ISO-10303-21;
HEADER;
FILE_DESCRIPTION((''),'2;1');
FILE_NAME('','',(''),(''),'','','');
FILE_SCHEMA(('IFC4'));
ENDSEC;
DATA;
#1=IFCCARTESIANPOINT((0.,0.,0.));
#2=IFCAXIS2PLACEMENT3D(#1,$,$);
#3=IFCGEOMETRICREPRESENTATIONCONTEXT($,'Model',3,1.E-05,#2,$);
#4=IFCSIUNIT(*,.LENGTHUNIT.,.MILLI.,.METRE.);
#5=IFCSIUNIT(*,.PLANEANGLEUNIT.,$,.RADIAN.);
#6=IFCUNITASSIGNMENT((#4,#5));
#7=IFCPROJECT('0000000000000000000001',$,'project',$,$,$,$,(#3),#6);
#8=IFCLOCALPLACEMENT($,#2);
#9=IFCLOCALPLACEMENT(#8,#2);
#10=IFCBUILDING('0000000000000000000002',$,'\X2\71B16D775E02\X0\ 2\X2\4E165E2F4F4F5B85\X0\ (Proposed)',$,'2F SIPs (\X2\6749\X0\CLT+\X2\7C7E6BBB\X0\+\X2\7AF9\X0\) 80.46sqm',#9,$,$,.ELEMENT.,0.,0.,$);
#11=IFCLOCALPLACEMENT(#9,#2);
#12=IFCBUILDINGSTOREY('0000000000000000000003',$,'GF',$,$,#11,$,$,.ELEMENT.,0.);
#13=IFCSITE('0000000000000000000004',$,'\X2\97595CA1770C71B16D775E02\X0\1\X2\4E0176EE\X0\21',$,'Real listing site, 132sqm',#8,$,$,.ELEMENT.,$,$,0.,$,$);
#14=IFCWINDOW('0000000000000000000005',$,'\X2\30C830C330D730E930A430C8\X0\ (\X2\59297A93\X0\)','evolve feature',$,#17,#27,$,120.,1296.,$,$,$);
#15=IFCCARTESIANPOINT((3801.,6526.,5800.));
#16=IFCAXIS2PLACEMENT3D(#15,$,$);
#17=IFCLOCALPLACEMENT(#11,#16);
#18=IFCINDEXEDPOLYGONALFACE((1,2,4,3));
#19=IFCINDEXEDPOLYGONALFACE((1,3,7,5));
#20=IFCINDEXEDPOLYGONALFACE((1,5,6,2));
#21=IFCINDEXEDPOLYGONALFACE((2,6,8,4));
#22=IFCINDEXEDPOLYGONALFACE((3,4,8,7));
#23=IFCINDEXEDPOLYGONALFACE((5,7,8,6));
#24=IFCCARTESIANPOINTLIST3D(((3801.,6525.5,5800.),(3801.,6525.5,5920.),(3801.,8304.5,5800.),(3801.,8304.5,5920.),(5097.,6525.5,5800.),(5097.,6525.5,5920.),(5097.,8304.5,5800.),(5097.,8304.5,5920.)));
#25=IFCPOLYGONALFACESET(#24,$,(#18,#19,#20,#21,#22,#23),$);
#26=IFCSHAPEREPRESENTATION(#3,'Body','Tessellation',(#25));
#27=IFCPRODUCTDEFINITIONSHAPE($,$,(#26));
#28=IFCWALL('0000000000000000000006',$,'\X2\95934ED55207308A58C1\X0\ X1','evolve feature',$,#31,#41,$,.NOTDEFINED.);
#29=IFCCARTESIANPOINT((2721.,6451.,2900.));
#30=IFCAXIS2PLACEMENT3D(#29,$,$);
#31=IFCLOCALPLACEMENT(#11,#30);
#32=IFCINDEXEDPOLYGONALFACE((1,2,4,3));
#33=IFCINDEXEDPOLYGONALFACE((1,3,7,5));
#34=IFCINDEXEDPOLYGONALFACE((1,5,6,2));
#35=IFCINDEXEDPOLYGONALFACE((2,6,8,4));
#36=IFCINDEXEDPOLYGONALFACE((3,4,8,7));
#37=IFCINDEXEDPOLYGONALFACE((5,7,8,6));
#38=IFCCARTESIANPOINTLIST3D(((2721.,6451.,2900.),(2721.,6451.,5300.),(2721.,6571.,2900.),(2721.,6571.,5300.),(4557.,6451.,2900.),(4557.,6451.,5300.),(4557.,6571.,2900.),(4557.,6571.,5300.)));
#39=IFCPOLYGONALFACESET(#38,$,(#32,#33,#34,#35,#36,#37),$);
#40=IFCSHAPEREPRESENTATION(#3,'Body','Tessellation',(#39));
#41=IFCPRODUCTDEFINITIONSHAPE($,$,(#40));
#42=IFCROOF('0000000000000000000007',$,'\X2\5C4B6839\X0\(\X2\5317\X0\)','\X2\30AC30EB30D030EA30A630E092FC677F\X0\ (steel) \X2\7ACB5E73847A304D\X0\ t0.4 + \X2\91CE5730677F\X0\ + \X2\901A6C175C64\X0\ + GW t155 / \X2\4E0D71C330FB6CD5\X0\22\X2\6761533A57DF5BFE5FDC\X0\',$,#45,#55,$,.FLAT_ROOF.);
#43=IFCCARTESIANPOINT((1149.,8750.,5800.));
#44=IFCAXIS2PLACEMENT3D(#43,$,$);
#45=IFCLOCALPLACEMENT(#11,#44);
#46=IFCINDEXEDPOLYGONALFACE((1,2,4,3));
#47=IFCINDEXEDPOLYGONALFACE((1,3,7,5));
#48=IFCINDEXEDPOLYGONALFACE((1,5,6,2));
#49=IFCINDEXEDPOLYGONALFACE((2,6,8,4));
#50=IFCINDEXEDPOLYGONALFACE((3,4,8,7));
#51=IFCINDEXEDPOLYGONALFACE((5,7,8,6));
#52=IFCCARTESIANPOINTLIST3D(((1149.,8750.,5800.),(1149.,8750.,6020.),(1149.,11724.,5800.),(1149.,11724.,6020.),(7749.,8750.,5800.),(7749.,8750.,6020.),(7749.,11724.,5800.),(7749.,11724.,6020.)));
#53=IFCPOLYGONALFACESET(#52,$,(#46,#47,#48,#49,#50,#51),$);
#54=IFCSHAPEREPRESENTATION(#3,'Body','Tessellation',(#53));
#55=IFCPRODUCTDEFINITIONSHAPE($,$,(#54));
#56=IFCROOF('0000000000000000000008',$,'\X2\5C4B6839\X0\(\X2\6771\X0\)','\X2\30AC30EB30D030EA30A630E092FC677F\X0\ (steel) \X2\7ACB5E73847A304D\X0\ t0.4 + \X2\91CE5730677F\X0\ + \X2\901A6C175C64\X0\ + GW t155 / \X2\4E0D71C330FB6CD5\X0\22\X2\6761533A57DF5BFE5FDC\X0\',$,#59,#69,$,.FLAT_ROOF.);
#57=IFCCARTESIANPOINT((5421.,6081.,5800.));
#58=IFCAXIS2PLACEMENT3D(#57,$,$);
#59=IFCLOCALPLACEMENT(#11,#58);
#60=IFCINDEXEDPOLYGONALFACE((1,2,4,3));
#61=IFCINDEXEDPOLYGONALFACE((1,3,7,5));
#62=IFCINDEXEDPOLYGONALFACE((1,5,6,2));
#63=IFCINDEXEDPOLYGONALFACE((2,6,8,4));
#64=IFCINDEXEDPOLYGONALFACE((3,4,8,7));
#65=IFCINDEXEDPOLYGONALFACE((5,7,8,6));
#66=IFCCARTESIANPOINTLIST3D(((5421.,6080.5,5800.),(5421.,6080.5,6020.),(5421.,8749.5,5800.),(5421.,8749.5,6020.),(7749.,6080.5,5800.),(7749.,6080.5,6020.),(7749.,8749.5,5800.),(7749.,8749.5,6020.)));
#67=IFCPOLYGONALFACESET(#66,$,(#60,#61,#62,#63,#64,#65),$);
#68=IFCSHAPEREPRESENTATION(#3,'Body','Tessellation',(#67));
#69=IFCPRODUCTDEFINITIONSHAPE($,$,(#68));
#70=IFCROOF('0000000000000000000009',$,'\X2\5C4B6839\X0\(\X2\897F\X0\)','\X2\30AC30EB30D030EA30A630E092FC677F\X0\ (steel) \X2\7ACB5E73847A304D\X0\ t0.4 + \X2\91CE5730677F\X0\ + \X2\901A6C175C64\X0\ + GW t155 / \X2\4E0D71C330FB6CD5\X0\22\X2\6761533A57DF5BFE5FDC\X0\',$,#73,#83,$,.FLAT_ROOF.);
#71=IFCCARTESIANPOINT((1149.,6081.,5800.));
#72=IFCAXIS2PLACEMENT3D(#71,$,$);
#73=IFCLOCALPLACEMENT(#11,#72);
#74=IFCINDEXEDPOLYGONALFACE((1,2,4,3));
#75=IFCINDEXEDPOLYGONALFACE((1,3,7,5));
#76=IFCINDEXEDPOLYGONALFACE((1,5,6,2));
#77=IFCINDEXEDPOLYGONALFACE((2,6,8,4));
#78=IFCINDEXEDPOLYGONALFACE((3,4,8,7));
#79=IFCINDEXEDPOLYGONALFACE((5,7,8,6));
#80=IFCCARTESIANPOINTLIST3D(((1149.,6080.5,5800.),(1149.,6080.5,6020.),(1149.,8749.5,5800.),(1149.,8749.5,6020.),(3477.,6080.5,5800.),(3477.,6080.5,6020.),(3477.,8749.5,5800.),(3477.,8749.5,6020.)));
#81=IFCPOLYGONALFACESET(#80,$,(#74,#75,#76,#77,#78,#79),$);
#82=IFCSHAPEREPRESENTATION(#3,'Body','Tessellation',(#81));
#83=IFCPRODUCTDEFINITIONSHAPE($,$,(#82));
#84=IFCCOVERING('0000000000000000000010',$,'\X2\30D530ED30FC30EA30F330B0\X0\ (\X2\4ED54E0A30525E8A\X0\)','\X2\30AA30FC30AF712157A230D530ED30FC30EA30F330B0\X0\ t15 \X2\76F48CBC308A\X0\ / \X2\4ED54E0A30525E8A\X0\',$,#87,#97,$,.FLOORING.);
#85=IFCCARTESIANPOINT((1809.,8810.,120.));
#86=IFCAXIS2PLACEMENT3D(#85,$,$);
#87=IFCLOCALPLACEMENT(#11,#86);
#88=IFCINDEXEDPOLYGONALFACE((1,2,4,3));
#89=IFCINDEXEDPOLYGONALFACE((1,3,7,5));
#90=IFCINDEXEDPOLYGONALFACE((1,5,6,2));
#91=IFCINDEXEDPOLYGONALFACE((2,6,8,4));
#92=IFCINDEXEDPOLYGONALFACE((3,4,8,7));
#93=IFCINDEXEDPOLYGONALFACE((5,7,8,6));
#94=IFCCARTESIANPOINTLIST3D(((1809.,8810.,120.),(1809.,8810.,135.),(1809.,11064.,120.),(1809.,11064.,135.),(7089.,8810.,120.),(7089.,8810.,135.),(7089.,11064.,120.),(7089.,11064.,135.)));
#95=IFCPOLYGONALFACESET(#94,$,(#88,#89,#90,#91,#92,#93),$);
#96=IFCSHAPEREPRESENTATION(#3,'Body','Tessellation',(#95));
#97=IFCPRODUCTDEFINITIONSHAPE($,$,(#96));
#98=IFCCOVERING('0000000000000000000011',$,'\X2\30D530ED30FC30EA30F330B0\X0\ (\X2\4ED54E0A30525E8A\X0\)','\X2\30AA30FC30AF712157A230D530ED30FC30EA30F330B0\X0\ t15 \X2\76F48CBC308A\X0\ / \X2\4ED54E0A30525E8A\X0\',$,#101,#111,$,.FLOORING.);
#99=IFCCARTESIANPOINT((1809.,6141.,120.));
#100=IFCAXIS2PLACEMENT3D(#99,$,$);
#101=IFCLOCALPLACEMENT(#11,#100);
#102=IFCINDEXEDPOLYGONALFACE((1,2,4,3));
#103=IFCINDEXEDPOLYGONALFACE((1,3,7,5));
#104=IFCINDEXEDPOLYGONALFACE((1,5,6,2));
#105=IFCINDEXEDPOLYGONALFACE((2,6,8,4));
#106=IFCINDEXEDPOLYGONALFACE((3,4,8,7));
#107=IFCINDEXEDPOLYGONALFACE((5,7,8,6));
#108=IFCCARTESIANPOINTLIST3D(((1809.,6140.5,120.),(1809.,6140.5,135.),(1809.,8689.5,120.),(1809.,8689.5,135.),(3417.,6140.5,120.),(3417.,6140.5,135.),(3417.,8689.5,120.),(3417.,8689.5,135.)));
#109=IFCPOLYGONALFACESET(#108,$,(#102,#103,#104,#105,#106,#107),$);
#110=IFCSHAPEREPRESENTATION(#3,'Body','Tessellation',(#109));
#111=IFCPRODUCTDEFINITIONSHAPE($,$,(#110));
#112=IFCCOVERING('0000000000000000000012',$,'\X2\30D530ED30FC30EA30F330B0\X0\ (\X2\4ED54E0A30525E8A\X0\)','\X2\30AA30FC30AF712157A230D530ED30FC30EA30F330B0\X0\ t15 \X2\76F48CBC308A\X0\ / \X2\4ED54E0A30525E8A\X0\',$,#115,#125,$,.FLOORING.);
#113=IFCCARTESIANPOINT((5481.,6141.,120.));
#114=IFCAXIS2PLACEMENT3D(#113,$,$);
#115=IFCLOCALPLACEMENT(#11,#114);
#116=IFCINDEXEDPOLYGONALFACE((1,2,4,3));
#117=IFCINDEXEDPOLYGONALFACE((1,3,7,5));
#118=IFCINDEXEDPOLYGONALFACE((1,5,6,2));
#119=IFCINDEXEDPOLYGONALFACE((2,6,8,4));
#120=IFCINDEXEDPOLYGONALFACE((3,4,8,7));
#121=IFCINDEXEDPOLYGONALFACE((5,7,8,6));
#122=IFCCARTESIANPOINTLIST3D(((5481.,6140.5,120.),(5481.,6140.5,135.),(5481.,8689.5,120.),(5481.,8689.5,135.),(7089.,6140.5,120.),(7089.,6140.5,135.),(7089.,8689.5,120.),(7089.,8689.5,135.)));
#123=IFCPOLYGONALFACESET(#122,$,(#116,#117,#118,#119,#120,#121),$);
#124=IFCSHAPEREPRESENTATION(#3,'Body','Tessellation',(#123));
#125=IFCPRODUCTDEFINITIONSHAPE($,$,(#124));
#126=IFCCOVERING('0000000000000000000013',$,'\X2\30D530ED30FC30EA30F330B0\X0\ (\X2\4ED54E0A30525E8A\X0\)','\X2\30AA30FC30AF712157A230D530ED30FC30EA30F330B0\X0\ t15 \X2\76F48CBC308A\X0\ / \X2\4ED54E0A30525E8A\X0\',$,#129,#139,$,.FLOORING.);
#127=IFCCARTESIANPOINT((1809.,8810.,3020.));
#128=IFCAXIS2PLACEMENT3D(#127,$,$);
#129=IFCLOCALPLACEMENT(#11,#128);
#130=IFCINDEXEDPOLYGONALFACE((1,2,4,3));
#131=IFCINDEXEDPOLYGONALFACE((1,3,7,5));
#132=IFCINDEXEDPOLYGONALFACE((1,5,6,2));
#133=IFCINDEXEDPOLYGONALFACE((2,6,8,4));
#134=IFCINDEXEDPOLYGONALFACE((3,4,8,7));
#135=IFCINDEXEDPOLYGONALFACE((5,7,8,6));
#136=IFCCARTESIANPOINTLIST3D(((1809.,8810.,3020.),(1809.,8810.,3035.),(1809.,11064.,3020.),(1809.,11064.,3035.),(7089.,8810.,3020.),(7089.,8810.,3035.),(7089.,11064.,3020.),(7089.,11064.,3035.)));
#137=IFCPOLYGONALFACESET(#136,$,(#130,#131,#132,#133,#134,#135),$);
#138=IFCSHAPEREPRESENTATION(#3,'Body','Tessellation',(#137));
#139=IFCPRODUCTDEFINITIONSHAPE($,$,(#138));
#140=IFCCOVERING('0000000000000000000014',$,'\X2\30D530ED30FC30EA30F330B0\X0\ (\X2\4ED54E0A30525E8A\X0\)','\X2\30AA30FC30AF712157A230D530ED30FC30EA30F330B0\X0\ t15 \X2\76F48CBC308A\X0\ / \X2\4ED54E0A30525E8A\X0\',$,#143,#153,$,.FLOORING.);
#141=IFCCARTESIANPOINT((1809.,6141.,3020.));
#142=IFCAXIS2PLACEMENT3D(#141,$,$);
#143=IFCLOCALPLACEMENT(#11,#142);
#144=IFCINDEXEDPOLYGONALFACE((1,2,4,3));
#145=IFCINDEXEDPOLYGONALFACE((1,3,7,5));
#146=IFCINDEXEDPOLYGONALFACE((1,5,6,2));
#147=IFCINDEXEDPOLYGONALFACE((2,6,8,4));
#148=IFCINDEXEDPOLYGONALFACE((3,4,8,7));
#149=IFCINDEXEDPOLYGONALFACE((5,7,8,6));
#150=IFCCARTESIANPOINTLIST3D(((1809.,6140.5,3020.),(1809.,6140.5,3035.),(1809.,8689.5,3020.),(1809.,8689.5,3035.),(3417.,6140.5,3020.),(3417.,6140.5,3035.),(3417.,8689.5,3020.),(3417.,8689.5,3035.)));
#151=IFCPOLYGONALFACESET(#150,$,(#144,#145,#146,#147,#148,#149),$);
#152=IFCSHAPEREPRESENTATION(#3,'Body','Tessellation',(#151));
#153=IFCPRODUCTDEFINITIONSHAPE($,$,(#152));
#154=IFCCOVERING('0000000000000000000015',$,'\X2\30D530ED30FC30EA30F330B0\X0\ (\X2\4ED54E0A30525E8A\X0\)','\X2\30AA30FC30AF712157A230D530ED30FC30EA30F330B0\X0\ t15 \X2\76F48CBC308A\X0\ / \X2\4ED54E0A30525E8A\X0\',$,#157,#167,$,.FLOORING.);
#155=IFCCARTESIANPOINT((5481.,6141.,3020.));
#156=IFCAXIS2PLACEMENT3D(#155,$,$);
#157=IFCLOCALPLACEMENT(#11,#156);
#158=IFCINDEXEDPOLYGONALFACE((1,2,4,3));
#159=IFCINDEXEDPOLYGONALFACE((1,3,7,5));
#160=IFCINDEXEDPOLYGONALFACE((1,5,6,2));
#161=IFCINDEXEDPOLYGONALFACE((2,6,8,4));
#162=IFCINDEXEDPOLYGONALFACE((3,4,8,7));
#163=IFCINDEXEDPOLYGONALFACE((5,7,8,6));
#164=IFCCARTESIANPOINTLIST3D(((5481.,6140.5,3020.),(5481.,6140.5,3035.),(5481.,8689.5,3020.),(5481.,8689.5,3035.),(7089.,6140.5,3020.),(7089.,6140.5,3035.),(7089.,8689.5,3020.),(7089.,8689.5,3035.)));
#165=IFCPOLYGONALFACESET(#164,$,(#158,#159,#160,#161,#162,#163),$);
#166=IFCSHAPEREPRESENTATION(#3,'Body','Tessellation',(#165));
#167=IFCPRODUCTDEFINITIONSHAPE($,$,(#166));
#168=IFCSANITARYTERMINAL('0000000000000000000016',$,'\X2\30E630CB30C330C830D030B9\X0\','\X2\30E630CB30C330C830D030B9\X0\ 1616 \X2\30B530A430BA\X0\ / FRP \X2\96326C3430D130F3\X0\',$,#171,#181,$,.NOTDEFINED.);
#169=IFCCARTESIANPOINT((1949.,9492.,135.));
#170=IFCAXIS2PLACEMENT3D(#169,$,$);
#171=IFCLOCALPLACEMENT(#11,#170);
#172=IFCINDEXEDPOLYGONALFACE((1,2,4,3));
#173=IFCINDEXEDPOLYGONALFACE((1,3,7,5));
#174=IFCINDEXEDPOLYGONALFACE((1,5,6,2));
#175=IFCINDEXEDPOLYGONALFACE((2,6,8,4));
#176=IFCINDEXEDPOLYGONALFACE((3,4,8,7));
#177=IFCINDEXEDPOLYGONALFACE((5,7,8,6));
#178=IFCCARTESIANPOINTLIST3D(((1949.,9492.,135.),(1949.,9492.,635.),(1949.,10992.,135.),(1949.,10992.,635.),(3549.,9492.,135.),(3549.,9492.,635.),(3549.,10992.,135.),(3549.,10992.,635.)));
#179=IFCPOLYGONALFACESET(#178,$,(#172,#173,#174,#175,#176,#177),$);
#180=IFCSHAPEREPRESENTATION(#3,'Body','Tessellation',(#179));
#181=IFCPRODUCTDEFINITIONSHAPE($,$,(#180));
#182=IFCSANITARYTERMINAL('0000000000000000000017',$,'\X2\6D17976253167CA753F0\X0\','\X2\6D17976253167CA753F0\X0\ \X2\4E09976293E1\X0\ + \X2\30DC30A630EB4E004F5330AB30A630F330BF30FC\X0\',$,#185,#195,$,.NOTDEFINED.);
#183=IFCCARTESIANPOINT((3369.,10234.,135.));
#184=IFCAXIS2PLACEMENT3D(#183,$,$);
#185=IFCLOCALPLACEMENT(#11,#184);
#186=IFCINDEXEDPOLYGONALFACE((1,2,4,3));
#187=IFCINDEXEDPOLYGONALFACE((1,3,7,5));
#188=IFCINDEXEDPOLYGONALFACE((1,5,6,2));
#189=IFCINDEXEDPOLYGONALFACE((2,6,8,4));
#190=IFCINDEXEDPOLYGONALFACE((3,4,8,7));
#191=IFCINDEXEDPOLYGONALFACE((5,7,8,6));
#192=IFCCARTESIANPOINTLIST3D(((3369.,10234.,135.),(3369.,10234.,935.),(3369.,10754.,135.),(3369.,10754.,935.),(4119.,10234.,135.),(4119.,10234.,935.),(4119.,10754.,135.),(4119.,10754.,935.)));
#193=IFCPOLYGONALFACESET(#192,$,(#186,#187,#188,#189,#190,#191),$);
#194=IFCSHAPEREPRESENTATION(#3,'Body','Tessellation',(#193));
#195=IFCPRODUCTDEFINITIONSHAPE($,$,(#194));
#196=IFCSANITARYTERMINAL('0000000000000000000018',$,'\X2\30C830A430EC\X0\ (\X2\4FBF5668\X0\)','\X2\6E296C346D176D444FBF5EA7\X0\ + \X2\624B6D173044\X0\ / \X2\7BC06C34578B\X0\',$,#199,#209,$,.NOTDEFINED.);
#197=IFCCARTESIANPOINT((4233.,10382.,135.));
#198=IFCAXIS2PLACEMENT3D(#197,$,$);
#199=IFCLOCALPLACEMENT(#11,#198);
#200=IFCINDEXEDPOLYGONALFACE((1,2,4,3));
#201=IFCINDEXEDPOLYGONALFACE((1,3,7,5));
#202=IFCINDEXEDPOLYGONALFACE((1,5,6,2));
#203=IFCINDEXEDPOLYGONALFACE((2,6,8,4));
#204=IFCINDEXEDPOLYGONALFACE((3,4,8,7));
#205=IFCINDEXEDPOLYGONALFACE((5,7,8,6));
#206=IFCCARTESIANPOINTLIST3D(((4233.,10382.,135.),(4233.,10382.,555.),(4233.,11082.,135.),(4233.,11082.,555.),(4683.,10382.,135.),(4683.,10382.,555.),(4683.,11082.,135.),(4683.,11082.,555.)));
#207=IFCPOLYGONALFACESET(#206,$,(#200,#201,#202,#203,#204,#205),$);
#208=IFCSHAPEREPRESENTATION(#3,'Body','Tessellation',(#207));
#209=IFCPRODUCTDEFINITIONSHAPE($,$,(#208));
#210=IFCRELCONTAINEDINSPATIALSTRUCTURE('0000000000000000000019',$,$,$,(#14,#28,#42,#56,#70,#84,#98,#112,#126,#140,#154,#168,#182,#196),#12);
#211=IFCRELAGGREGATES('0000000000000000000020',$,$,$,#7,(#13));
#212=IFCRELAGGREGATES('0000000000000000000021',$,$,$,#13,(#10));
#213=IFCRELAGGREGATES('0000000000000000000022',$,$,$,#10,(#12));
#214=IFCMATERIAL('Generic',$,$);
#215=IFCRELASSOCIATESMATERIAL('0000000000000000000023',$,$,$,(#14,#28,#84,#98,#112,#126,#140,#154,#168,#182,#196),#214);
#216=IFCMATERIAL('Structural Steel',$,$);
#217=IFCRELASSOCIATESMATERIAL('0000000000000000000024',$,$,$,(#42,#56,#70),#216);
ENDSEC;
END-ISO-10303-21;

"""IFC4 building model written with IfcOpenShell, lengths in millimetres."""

from ifc_helpers import new_model, si_unit, frame, frame_2d, origin, place, context, project, spatial, rectangle, extrude, material, element, save


model = new_model("IFC4")

# Units and contexts
model_context = context("Model", 3, precision=1e-05, world=origin())
ifc_project = project(units=[si_unit("LENGTHUNIT", "METRE", prefix="MILLI"), si_unit("PLANEANGLEUNIT", "RADIAN")], contexts=[model_context])

# Site, building, storey
site_placement = place(None, origin())
site = spatial("IfcSite", under=ifc_project, at=site_placement, Name="静岡県熱海市1丁目21", ObjectType="Real listing site, 132sqm", CompositionType="ELEMENT", RefElevation=0.0)
building_placement = place(site_placement, origin())
building = spatial("IfcBuilding", under=site, at=building_placement, Name="熱海市 2世帯住宅 (Proposed)", ObjectType="2F SIPs (杉CLT+籾殻+竹) 80.46sqm", CompositionType="ELEMENT", ElevationOfRefHeight=0.0, ElevationOfTerrain=0.0)
storey_placement = place(building_placement, origin())
storey = spatial("IfcBuildingStorey", under=building, at=storey_placement, Name="GF", CompositionType="ELEMENT", Elevation=0.0)

# Window
ifc_material_1 = material(Name="Generic")
window_1_placement = place(storey_placement, frame((3801.0, 6526.0, 5800.0)))
element("IfcWindow", 1, at=window_1_placement, inside=storey, material=ifc_material_1, Name="トップライト (天窓)", Description="evolve feature", OverallHeight=120.0, OverallWidth=1296.0, context=model_context, shape_type="SweptSolid", body=[
    extrude(rectangle(XDim=1296.0, YDim=1779.0, at=frame_2d((648.0, 889.0))), frame((3801.0, 6526.0, 5800.0)), (0.0, 0.0, 1.0), 120.0),
])

# Wall
wall_1_placement = place(storey_placement, frame((2721.0, 6451.0, 2900.0)))
element("IfcWall", 2, at=wall_1_placement, inside=storey, material=ifc_material_1, Name="間仕切り壁 X1", Description="evolve feature", PredefinedType="NOTDEFINED", context=model_context, shape_type="SweptSolid", body=[
    extrude(rectangle(XDim=1836.0, YDim=120.0, at=frame_2d((918.0, 60.0))), frame((2721.0, 6451.0, 2900.0)), (0.0, 0.0, 1.0), 2400.0),
])

# Roofs
ifc_material_2 = material(Name="Structural Steel")
roof_1_placement = place(storey_placement, frame((1149.0, 8750.0, 5800.0)))
element("IfcRoof", 3, at=roof_1_placement, inside=storey, material=ifc_material_2, Name="屋根(北)", Description="ガルバリウム鋼板 (steel) 立平葺き t0.4 + 野地板 + 通気層 + GW t155 / 不燃・法22条区域対応", PredefinedType="FLAT_ROOF", context=model_context, shape_type="SweptSolid", body=[
    extrude(rectangle(XDim=6600.0, YDim=2974.0, at=frame_2d((3300.0, 1487.0))), frame((1149.0, 8750.0, 5800.0)), (0.0, 0.0, 1.0), 220.0),
])
roof_2_placement = place(storey_placement, frame((5421.0, 6081.0, 5800.0)))
element("IfcRoof", 4, at=roof_2_placement, inside=storey, material=ifc_material_2, Name="屋根(東)", Description="ガルバリウム鋼板 (steel) 立平葺き t0.4 + 野地板 + 通気層 + GW t155 / 不燃・法22条区域対応", PredefinedType="FLAT_ROOF", context=model_context, shape_type="SweptSolid", body=[
    extrude(rectangle(XDim=2328.0, YDim=2669.0, at=frame_2d((1164.0, 1334.0))), frame((5421.0, 6081.0, 5800.0)), (0.0, 0.0, 1.0), 220.0),
])
roof_3_placement = place(storey_placement, frame((1149.0, 6081.0, 5800.0)))
element("IfcRoof", 5, at=roof_3_placement, inside=storey, material=ifc_material_2, Name="屋根(西)", Description="ガルバリウム鋼板 (steel) 立平葺き t0.4 + 野地板 + 通気層 + GW t155 / 不燃・法22条区域対応", PredefinedType="FLAT_ROOF", context=model_context, shape_type="SweptSolid", body=[
    extrude(rectangle(XDim=2328.0, YDim=2669.0, at=frame_2d((1164.0, 1334.0))), frame((1149.0, 6081.0, 5800.0)), (0.0, 0.0, 1.0), 220.0),
])

# Coverings
covering_1_placement = place(storey_placement, frame((1809.0, 8810.0, 120.0)))
element("IfcCovering", 6, at=covering_1_placement, inside=storey, material=ifc_material_1, Name="フローリング (仕上げ床)", Description="オーク無垢フローリング t15 直貼り / 仕上げ床", PredefinedType="FLOORING", context=model_context, shape_type="SweptSolid", body=[
    extrude(rectangle(XDim=5280.0, YDim=2254.0, at=frame_2d((2640.0, 1127.0))), frame((1809.0, 8810.0, 120.0)), (0.0, 0.0, 1.0), 15.0),
])
covering_2_placement = place(storey_placement, frame((1809.0, 6141.0, 120.0)))
element("IfcCovering", 7, at=covering_2_placement, inside=storey, material=ifc_material_1, Name="フローリング (仕上げ床)", Description="オーク無垢フローリング t15 直貼り / 仕上げ床", PredefinedType="FLOORING", context=model_context, shape_type="SweptSolid", body=[
    extrude(rectangle(XDim=1608.0, YDim=2549.0, at=frame_2d((804.0, 1274.0))), frame((1809.0, 6141.0, 120.0)), (0.0, 0.0, 1.0), 15.0),
])
covering_3_placement = place(storey_placement, frame((5481.0, 6141.0, 120.0)))
element("IfcCovering", 8, at=covering_3_placement, inside=storey, material=ifc_material_1, Name="フローリング (仕上げ床)", Description="オーク無垢フローリング t15 直貼り / 仕上げ床", PredefinedType="FLOORING", context=model_context, shape_type="SweptSolid", body=[
    extrude(rectangle(XDim=1608.0, YDim=2549.0, at=frame_2d((804.0, 1274.0))), frame((5481.0, 6141.0, 120.0)), (0.0, 0.0, 1.0), 15.0),
])
covering_4_placement = place(storey_placement, frame((1809.0, 8810.0, 3020.0)))
element("IfcCovering", 9, at=covering_4_placement, inside=storey, material=ifc_material_1, Name="フローリング (仕上げ床)", Description="オーク無垢フローリング t15 直貼り / 仕上げ床", PredefinedType="FLOORING", context=model_context, shape_type="SweptSolid", body=[
    extrude(rectangle(XDim=5280.0, YDim=2254.0, at=frame_2d((2640.0, 1127.0))), frame((1809.0, 8810.0, 3020.0)), (0.0, 0.0, 1.0), 15.0),
])
covering_5_placement = place(storey_placement, frame((1809.0, 6141.0, 3020.0)))
element("IfcCovering", 10, at=covering_5_placement, inside=storey, material=ifc_material_1, Name="フローリング (仕上げ床)", Description="オーク無垢フローリング t15 直貼り / 仕上げ床", PredefinedType="FLOORING", context=model_context, shape_type="SweptSolid", body=[
    extrude(rectangle(XDim=1608.0, YDim=2549.0, at=frame_2d((804.0, 1274.0))), frame((1809.0, 6141.0, 3020.0)), (0.0, 0.0, 1.0), 15.0),
])
covering_6_placement = place(storey_placement, frame((5481.0, 6141.0, 3020.0)))
element("IfcCovering", 11, at=covering_6_placement, inside=storey, material=ifc_material_1, Name="フローリング (仕上げ床)", Description="オーク無垢フローリング t15 直貼り / 仕上げ床", PredefinedType="FLOORING", context=model_context, shape_type="SweptSolid", body=[
    extrude(rectangle(XDim=1608.0, YDim=2549.0, at=frame_2d((804.0, 1274.0))), frame((5481.0, 6141.0, 3020.0)), (0.0, 0.0, 1.0), 15.0),
])

# Sanitary terminals
sanitary_terminal_1_placement = place(storey_placement, frame((1949.0, 9492.0, 135.0)))
element("IfcSanitaryTerminal", 12, at=sanitary_terminal_1_placement, inside=storey, material=ifc_material_1, Name="ユニットバス", Description="ユニットバス 1616 サイズ / FRP 防水パン", PredefinedType="NOTDEFINED", context=model_context, shape_type="SweptSolid", body=[
    extrude(rectangle(XDim=1600.0, YDim=1500.0, at=frame_2d((800.0, 750.0))), frame((1949.0, 9492.0, 135.0)), (0.0, 0.0, 1.0), 500.0),
])
sanitary_terminal_2_placement = place(storey_placement, frame((3369.0, 10234.0, 135.0)))
element("IfcSanitaryTerminal", 13, at=sanitary_terminal_2_placement, inside=storey, material=ifc_material_1, Name="洗面化粧台", Description="洗面化粧台 三面鏡 + ボウル一体カウンター", PredefinedType="NOTDEFINED", context=model_context, shape_type="SweptSolid", body=[
    extrude(rectangle(XDim=750.0, YDim=520.0, at=frame_2d((375.0, 260.0))), frame((3369.0, 10234.0, 135.0)), (0.0, 0.0, 1.0), 800.0),
])
sanitary_terminal_3_placement = place(storey_placement, frame((4233.0, 10382.0, 135.0)))
element("IfcSanitaryTerminal", 14, at=sanitary_terminal_3_placement, inside=storey, material=ifc_material_1, Name="トイレ (便器)", Description="温水洗浄便座 + 手洗い / 節水型", PredefinedType="NOTDEFINED", context=model_context, shape_type="SweptSolid", body=[
    extrude(rectangle(XDim=450.0, YDim=700.0, at=frame_2d((225.0, 350.0))), frame((4233.0, 10382.0, 135.0)), (0.0, 0.0, 1.0), 420.0),
])

save(model, "model.ifc")
